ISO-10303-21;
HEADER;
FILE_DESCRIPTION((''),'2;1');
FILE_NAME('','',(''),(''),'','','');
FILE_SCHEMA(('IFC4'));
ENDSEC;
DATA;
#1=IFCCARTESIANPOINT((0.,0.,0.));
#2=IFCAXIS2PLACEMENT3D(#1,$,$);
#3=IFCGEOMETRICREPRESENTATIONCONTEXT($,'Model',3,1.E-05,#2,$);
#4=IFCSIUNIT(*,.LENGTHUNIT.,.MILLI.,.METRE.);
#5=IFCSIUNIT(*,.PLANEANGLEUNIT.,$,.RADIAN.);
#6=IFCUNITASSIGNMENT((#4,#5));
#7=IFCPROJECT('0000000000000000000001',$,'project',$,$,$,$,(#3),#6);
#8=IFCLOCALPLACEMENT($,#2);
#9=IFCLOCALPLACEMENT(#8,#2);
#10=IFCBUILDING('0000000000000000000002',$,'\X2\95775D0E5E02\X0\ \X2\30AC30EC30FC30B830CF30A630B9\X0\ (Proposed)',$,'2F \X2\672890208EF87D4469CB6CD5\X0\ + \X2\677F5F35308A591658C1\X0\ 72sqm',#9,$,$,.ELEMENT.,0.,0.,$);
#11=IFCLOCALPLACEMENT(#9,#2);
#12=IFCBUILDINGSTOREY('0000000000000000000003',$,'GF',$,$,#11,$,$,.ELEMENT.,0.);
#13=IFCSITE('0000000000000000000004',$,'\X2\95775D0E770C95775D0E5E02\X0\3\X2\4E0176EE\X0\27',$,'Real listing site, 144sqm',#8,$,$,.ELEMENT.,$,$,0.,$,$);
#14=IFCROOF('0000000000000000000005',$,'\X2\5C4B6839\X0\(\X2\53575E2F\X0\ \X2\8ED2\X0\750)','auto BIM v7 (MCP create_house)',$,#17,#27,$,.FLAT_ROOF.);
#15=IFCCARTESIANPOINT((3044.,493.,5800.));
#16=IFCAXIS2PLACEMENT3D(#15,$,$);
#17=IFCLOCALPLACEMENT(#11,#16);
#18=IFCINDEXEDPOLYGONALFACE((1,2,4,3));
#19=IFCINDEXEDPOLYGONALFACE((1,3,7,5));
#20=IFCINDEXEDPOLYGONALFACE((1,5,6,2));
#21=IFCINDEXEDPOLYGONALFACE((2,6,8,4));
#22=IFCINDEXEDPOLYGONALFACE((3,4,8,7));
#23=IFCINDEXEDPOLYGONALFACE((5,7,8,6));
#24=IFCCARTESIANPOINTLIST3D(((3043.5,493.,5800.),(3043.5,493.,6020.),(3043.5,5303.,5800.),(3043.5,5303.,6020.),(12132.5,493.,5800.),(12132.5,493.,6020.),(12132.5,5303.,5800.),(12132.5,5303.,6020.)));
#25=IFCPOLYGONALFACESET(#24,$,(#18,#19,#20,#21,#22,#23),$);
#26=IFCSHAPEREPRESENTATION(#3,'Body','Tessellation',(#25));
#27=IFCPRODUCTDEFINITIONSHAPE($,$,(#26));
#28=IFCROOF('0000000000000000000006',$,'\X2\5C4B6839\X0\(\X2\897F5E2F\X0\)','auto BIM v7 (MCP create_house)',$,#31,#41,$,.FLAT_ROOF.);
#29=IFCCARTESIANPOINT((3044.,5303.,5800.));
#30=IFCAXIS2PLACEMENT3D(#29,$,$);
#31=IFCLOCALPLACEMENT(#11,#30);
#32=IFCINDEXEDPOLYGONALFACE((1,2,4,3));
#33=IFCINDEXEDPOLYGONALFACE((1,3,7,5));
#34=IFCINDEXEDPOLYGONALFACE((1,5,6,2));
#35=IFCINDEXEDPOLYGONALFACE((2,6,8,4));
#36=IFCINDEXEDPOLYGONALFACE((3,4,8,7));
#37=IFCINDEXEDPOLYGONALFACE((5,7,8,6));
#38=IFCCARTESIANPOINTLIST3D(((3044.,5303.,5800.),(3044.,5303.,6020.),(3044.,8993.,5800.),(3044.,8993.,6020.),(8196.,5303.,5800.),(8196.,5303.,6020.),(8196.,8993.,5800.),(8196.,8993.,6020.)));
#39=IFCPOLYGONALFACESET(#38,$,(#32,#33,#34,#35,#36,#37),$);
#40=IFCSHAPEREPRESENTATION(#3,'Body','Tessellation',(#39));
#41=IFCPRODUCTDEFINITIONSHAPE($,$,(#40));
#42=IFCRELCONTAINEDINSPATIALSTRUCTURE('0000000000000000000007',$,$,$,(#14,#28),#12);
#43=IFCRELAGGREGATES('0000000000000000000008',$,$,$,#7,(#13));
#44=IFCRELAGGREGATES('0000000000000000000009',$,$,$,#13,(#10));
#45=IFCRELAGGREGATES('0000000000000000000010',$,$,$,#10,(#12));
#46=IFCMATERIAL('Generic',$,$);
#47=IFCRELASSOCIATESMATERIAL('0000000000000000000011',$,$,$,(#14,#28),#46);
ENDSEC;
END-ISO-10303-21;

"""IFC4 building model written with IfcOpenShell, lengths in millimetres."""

from ifc_helpers import new_model, si_unit, frame, frame_2d, origin, place, context, project, spatial, rectangle, extrude, material, element, save


model = new_model("IFC4")

# Units and contexts
model_context = context("Model", 3, precision=1e-05, world=origin())
ifc_project = project(units=[si_unit("LENGTHUNIT", "METRE", prefix="MILLI"), si_unit("PLANEANGLEUNIT", "RADIAN")], contexts=[model_context])

# Site, building, storey
site_placement = place(None, origin())
site = spatial("IfcSite", under=ifc_project, at=site_placement, Name="長崎県長崎市3丁目27", ObjectType="Real listing site, 144sqm", CompositionType="ELEMENT", RefElevation=0.0)
building_placement = place(site_placement, origin())
building = spatial("IfcBuilding", under=site, at=building_placement, Name="長崎市 ガレージハウス (Proposed)", ObjectType="2F 木造軸組構法 + 板張り外壁 72sqm", CompositionType="ELEMENT", ElevationOfRefHeight=0.0, ElevationOfTerrain=0.0)
storey_placement = place(building_placement, origin())
storey = spatial("IfcBuildingStorey", under=building, at=storey_placement, Name="GF", CompositionType="ELEMENT", Elevation=0.0)

# Shared definitions
ifc_material = material(Name="Generic")

# Roofs
roof_1_placement = place(storey_placement, frame((3044.0, 493.0, 5800.0)))
element("IfcRoof", 1, at=roof_1_placement, inside=storey, material=ifc_material, Name="屋根(南帯 軒750)", Description="auto BIM v7 (MCP create_house)", PredefinedType="FLAT_ROOF", context=model_context, shape_type="SweptSolid", body=[
    extrude(rectangle(XDim=9089.0, YDim=4810.0, at=frame_2d((4544.0, 2405.0))), frame((3044.0, 493.0, 5800.0)), (0.0, 0.0, 1.0), 220.0),
])
roof_2_placement = place(storey_placement, frame((3044.0, 5303.0, 5800.0)))
element("IfcRoof", 2, at=roof_2_placement, inside=storey, material=ifc_material, Name="屋根(西帯)", Description="auto BIM v7 (MCP create_house)", PredefinedType="FLAT_ROOF", context=model_context, shape_type="SweptSolid", body=[
    extrude(rectangle(XDim=5152.0, YDim=3690.0, at=frame_2d((2576.0, 1845.0))), frame((3044.0, 5303.0, 5800.0)), (0.0, 0.0, 1.0), 220.0),
])

save(model, "model.ifc")
